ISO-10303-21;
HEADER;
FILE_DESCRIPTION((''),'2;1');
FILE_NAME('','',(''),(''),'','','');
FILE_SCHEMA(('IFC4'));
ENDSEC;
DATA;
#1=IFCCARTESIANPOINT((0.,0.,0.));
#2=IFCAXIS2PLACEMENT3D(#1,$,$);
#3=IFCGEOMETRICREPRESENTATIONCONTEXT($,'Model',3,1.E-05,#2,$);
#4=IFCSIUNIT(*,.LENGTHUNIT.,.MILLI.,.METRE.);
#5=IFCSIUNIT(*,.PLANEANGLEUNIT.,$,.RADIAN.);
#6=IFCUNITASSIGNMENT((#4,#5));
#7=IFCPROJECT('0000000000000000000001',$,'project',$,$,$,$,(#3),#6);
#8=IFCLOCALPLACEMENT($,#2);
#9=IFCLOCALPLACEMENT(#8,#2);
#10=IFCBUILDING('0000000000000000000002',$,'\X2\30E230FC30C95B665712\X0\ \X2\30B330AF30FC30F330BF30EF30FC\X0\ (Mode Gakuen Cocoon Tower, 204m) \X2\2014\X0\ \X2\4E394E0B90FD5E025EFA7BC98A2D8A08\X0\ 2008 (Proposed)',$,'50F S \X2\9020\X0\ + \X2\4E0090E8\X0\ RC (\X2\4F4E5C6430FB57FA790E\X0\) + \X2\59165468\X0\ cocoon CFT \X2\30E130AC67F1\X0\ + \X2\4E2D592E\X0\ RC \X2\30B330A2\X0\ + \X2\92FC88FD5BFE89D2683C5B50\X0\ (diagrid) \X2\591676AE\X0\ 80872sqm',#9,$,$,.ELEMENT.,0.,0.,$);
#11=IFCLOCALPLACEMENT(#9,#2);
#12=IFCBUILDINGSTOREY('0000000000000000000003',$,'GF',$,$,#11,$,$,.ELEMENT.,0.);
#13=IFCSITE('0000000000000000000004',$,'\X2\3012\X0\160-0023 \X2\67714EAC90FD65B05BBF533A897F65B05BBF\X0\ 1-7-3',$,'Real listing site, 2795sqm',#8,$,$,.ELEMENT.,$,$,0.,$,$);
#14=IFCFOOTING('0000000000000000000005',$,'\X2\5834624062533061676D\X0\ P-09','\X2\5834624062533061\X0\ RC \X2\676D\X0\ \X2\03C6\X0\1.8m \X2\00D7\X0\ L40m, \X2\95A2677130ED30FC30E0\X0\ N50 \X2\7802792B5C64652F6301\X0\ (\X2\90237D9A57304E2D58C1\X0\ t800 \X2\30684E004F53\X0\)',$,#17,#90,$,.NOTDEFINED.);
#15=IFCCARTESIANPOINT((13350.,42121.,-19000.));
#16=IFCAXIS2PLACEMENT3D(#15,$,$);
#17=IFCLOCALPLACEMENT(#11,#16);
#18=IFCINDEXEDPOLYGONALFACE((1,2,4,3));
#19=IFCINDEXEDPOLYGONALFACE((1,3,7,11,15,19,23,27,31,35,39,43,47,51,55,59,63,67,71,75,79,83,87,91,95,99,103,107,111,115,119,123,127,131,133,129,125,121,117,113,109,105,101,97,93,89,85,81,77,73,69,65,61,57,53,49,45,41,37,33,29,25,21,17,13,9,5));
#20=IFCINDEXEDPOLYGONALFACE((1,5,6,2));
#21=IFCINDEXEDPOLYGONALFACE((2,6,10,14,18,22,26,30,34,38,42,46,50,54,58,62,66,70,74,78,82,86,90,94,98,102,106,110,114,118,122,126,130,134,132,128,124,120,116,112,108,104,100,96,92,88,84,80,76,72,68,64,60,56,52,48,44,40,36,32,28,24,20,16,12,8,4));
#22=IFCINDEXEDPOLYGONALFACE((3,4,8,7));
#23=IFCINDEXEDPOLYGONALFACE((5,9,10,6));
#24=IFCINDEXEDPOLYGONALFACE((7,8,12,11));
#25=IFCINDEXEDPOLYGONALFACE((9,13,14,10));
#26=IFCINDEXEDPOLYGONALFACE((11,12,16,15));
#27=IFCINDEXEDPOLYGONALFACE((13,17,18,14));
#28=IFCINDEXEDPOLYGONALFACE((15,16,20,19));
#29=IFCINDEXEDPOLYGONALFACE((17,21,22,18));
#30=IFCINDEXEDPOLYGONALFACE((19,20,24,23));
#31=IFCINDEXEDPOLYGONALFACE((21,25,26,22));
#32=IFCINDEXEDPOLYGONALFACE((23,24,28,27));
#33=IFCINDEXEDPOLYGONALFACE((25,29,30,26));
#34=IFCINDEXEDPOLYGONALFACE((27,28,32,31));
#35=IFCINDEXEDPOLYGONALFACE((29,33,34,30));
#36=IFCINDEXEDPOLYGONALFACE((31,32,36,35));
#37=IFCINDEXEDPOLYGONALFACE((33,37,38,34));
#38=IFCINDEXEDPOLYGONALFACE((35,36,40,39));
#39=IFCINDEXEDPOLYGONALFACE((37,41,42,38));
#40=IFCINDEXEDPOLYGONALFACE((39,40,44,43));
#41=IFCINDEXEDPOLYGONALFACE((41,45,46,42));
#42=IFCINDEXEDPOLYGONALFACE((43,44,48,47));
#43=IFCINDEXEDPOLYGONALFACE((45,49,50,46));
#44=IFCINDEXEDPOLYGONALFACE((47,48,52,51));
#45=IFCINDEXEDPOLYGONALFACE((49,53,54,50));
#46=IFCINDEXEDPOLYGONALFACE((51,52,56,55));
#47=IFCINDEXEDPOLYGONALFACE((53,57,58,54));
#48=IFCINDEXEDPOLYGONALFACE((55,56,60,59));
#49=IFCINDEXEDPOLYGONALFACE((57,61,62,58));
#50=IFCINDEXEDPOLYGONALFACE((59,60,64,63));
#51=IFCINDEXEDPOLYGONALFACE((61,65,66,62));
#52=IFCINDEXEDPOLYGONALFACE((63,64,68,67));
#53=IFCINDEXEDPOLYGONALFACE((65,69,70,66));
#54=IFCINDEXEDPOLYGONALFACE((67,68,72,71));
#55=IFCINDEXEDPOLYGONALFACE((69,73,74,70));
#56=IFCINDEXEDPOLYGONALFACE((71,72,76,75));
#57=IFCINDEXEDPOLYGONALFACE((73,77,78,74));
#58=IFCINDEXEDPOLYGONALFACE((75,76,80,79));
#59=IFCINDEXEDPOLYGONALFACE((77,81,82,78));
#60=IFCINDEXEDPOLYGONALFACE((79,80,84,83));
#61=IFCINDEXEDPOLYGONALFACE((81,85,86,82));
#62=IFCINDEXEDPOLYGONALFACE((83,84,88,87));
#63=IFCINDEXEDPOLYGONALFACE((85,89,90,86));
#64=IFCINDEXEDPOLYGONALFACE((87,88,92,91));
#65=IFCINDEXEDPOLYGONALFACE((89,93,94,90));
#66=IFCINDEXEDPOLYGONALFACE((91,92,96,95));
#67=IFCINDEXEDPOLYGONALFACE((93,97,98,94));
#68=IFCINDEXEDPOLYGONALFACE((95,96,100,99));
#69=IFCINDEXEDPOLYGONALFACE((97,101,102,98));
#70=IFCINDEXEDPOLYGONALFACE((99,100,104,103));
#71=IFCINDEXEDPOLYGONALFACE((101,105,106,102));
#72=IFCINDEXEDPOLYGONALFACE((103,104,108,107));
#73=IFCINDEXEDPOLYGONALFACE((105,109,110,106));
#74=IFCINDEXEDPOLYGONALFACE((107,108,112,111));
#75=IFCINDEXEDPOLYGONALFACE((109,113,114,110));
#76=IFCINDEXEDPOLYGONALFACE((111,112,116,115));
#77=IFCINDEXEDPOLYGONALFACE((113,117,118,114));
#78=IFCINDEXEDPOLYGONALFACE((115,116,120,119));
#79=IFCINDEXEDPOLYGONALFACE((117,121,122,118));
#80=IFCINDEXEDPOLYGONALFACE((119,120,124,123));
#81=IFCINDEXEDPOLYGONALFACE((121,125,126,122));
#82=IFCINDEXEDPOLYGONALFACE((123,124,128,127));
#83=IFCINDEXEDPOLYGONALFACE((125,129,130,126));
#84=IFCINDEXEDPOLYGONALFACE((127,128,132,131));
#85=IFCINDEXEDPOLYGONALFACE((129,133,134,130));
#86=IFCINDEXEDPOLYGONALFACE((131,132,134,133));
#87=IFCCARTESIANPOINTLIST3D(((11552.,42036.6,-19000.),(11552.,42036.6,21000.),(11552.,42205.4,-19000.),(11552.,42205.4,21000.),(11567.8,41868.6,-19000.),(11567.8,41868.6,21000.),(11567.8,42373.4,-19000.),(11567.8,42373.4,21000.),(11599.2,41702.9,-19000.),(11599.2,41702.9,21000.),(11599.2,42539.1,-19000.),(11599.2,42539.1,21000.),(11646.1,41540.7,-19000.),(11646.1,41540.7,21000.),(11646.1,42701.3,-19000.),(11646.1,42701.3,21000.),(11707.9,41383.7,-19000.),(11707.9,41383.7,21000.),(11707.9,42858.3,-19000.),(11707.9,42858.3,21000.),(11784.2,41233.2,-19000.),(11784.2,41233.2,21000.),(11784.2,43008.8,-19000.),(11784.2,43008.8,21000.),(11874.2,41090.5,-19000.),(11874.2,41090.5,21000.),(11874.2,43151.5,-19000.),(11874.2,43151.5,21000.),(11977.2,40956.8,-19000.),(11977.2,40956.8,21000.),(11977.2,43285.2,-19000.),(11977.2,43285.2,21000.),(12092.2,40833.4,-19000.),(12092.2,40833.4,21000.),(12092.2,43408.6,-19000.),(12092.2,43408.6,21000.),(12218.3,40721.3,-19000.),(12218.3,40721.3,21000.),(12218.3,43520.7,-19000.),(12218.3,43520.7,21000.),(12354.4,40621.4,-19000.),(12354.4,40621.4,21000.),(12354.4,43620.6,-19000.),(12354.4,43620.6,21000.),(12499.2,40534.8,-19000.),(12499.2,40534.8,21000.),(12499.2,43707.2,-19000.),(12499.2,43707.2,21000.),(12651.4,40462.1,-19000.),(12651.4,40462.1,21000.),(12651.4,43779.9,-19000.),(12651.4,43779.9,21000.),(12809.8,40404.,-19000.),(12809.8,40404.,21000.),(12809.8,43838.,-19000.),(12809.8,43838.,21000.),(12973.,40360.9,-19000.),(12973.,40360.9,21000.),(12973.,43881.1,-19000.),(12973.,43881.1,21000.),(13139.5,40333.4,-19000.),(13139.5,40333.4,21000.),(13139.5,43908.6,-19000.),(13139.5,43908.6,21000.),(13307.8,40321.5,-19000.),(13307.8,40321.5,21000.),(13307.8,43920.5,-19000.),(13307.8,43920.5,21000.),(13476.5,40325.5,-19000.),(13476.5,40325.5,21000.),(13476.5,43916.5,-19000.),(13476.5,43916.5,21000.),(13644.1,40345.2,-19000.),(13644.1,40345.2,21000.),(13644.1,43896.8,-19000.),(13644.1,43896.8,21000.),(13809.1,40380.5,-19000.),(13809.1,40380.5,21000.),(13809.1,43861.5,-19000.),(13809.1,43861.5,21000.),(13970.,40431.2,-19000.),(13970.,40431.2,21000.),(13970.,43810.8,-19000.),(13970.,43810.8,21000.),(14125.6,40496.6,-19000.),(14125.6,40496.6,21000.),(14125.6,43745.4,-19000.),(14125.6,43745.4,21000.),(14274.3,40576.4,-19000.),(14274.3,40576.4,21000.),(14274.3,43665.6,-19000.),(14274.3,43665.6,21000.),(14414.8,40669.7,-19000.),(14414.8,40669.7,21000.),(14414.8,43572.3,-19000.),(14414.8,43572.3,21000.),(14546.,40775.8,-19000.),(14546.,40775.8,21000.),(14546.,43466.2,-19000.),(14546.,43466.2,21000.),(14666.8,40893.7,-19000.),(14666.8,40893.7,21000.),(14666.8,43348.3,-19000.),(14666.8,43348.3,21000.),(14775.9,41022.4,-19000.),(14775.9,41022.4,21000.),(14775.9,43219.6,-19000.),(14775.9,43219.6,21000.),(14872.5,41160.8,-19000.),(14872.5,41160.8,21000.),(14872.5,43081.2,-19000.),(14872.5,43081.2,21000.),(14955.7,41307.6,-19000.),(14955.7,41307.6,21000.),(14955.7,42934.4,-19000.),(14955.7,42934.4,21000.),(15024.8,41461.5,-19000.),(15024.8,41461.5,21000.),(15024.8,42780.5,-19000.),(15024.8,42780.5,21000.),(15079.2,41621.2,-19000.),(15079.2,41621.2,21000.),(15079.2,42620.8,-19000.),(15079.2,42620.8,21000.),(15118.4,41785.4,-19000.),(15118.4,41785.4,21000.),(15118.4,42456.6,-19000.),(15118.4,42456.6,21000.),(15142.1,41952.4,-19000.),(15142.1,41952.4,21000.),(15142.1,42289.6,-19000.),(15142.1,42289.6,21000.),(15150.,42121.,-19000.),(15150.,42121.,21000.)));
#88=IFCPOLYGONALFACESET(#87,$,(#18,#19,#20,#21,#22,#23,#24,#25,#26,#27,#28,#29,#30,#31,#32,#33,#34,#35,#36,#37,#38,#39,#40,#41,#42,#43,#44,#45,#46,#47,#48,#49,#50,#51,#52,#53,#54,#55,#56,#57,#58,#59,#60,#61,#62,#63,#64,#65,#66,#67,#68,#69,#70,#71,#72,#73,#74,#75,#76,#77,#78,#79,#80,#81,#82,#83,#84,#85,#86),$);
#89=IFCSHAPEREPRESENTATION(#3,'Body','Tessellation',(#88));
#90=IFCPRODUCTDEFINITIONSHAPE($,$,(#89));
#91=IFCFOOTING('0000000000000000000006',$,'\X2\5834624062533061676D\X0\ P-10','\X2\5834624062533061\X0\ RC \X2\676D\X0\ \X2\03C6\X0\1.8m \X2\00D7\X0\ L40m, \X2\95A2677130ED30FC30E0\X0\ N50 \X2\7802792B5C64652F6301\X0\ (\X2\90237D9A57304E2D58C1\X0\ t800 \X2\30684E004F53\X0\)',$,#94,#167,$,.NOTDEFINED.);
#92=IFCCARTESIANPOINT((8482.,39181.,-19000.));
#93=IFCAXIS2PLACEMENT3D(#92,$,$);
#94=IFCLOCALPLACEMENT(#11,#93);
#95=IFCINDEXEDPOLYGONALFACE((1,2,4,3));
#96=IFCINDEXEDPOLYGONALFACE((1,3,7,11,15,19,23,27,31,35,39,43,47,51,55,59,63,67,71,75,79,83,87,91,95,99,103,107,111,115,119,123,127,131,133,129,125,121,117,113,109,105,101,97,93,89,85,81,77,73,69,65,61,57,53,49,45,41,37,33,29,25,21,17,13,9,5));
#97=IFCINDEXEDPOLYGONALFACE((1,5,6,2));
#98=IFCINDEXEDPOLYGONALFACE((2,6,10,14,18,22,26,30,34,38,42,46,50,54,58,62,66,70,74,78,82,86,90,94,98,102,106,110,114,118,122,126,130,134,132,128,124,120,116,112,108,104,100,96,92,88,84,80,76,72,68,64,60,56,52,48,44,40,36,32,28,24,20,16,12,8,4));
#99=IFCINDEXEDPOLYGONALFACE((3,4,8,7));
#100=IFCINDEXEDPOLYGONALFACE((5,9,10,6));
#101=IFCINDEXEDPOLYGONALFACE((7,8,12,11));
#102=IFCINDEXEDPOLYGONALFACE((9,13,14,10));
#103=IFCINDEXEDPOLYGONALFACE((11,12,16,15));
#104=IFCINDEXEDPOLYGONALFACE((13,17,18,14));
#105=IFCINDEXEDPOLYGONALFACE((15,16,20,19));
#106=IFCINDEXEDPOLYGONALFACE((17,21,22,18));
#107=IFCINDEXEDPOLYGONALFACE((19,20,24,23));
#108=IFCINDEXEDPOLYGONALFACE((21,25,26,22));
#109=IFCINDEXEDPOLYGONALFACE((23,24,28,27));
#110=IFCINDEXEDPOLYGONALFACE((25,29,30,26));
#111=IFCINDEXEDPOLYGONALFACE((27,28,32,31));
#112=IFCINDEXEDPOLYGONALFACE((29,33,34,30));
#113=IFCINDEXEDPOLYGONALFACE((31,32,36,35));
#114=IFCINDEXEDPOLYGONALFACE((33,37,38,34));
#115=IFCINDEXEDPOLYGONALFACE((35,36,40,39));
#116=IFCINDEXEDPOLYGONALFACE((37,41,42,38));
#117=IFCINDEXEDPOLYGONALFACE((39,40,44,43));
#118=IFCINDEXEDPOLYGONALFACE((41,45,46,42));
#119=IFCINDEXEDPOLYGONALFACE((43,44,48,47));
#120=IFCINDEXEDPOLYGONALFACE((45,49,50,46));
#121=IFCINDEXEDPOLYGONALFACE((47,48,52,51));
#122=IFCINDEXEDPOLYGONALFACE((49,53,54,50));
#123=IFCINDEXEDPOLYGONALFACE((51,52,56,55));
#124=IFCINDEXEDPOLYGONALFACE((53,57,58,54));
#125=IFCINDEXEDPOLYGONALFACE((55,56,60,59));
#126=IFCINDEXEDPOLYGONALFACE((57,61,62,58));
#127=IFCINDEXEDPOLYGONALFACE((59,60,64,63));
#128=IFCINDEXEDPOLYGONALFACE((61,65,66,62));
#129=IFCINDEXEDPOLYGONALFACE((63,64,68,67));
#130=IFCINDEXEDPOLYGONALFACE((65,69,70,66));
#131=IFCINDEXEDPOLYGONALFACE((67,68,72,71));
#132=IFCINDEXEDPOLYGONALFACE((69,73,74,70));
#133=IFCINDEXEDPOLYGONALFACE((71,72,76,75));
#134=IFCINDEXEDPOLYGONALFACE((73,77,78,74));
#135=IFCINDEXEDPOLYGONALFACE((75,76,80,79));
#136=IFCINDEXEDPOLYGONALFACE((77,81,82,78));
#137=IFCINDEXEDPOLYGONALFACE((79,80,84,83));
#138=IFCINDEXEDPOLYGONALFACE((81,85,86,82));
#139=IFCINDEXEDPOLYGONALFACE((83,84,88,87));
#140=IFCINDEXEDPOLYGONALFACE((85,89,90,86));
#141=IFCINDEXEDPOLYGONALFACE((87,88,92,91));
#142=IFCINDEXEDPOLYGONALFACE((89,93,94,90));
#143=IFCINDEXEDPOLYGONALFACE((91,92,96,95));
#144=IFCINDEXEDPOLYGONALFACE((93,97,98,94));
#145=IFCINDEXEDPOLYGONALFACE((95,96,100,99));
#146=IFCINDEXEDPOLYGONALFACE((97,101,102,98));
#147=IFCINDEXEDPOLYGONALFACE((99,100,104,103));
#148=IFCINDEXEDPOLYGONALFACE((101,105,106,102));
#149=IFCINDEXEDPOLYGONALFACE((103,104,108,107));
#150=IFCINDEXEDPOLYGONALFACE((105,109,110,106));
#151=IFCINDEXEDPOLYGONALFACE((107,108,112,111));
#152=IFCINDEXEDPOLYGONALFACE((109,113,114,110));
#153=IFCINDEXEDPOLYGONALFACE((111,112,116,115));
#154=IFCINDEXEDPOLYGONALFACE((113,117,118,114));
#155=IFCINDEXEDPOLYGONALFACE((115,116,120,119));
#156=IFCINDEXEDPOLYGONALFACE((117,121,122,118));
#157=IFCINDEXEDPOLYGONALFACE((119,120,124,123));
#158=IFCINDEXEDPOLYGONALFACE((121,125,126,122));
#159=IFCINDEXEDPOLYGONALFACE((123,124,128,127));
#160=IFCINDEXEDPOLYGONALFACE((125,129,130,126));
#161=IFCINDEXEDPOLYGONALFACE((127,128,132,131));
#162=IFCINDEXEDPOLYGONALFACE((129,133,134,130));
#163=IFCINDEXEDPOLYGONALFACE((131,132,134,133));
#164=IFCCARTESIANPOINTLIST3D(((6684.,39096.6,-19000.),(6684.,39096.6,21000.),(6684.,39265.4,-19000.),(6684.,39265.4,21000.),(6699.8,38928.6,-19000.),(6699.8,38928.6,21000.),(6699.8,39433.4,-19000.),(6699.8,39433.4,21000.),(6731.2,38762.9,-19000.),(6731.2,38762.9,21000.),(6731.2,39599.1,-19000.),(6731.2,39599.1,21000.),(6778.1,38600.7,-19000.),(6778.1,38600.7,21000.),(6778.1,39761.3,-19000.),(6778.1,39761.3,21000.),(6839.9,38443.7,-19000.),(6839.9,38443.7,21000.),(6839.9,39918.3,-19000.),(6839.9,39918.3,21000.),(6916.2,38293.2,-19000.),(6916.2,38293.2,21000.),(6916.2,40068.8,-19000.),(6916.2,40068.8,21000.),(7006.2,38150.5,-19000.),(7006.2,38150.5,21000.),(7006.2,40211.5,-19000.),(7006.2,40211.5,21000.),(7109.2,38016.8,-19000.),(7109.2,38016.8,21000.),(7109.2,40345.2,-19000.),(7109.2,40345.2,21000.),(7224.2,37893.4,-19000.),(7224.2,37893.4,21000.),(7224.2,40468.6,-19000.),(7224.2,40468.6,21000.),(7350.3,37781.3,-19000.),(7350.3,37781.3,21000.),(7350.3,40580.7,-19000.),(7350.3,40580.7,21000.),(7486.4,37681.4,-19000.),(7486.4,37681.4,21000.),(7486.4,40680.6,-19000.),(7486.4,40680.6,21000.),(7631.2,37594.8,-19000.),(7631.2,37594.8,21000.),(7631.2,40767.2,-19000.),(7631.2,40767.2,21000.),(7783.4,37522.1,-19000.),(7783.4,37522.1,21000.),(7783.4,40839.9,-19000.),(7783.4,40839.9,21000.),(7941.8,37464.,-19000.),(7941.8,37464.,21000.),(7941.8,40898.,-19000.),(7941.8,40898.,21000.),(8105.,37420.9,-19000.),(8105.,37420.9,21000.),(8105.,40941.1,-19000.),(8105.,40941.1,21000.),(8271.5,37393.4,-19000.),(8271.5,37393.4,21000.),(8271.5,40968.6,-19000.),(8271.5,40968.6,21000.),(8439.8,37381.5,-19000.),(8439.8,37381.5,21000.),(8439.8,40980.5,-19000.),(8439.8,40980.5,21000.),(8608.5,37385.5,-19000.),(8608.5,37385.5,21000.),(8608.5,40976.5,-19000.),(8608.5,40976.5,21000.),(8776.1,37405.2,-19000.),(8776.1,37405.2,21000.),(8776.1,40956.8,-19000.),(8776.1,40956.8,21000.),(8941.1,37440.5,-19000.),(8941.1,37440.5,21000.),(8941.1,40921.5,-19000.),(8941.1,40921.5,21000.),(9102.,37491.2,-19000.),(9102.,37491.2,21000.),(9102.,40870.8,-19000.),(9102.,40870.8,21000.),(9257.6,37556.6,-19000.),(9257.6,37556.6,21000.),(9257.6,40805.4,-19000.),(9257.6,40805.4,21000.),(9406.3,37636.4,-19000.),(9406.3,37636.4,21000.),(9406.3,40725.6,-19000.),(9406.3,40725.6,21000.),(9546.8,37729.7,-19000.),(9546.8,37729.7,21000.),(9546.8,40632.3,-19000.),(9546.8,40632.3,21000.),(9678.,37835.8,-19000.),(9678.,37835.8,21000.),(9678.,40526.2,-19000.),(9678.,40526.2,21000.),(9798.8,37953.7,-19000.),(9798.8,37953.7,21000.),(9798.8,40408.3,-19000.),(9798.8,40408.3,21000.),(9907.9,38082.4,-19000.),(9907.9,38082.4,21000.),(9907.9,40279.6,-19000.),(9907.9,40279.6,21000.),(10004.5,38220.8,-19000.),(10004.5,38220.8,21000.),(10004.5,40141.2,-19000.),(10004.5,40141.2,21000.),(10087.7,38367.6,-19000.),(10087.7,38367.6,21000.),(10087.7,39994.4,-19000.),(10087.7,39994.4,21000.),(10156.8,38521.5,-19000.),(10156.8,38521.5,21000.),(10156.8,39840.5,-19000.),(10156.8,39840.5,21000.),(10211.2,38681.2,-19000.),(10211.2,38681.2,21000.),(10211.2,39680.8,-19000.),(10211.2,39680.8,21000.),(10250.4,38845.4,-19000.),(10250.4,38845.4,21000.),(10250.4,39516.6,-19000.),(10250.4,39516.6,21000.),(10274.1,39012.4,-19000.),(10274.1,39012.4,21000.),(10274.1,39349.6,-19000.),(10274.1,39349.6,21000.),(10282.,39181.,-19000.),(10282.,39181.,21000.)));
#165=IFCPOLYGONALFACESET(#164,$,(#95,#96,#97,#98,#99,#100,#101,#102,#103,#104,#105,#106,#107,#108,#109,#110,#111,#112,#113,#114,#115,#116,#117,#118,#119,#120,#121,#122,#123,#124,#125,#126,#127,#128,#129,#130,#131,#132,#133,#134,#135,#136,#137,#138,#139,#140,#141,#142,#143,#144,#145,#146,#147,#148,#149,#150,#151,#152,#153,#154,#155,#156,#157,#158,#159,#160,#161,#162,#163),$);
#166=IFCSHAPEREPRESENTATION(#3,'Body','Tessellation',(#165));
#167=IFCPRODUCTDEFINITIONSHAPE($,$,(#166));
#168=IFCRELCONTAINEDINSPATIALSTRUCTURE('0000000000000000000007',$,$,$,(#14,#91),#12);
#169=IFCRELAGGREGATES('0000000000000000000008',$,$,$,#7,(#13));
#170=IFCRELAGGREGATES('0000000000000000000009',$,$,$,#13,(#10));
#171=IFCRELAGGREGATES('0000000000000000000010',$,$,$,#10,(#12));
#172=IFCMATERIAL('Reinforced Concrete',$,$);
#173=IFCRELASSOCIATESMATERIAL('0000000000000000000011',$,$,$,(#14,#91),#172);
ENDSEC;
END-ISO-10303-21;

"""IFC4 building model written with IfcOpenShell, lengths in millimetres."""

from ifc_helpers import new_model, si_unit, frame, origin, origin_2d, place, context, project, spatial, circle, extrude, material, element, save


model = new_model("IFC4")

# Units and contexts
model_context = context("Model", 3, precision=1e-05, world=origin())
ifc_project = project(units=[si_unit("LENGTHUNIT", "METRE", prefix="MILLI"), si_unit("PLANEANGLEUNIT", "RADIAN")], contexts=[model_context])

# Site, building, storey
site_placement = place(None, origin())
site = spatial("IfcSite", under=ifc_project, at=site_placement, Name="〒160-0023 東京都新宿区西新宿 1-7-3", ObjectType="Real listing site, 2795sqm", CompositionType="ELEMENT", RefElevation=0.0)
building_placement = place(site_placement, origin())
building = spatial("IfcBuilding", under=site, at=building_placement, Name="モード学園 コクーンタワー (Mode Gakuen Cocoon Tower, 204m) — 丹下都市建築設計 2008 (Proposed)", ObjectType="50F S 造 + 一部 RC (低層・基礎) + 外周 cocoon CFT メガ柱 + 中央 RC コア + 鋼製対角格子 (diagrid) 外皮 80872sqm", CompositionType="ELEMENT", ElevationOfRefHeight=0.0, ElevationOfTerrain=0.0)
storey_placement = place(building_placement, origin())
storey = spatial("IfcBuildingStorey", under=building, at=storey_placement, Name="GF", CompositionType="ELEMENT", Elevation=0.0)

# Footings
ifc_material_1 = material(Name="Reinforced Concrete")
footing_1_placement = place(storey_placement, frame((13350.0, 42121.0, -19000.0)))
element("IfcFooting", 1, at=footing_1_placement, inside=storey, material=ifc_material_1, Name="場所打ち杭 P-09", Description="場所打ち RC 杭 φ1.8m × L40m, 関東ローム N50 砂礫層支持 (連続地中壁 t800 と一体)", PredefinedType="NOTDEFINED", context=model_context, shape_type="SweptSolid", body=[
    extrude(circle(Radius=1800.0, at=origin_2d()), frame((13350.0, 42121.0, -19000.0)), (0.0, 0.0, 1.0), 40000.0),
])
footing_2_placement = place(storey_placement, frame((8482.0, 39181.0, -19000.0)))
element("IfcFooting", 2, at=footing_2_placement, inside=storey, material=ifc_material_1, Name="場所打ち杭 P-10", Description="場所打ち RC 杭 φ1.8m × L40m, 関東ローム N50 砂礫層支持 (連続地中壁 t800 と一体)", PredefinedType="NOTDEFINED", context=model_context, shape_type="SweptSolid", body=[
    extrude(circle(Radius=1800.0, at=origin_2d()), frame((8482.0, 39181.0, -19000.0)), (0.0, 0.0, 1.0), 40000.0),
])

save(model, "model.ifc")
